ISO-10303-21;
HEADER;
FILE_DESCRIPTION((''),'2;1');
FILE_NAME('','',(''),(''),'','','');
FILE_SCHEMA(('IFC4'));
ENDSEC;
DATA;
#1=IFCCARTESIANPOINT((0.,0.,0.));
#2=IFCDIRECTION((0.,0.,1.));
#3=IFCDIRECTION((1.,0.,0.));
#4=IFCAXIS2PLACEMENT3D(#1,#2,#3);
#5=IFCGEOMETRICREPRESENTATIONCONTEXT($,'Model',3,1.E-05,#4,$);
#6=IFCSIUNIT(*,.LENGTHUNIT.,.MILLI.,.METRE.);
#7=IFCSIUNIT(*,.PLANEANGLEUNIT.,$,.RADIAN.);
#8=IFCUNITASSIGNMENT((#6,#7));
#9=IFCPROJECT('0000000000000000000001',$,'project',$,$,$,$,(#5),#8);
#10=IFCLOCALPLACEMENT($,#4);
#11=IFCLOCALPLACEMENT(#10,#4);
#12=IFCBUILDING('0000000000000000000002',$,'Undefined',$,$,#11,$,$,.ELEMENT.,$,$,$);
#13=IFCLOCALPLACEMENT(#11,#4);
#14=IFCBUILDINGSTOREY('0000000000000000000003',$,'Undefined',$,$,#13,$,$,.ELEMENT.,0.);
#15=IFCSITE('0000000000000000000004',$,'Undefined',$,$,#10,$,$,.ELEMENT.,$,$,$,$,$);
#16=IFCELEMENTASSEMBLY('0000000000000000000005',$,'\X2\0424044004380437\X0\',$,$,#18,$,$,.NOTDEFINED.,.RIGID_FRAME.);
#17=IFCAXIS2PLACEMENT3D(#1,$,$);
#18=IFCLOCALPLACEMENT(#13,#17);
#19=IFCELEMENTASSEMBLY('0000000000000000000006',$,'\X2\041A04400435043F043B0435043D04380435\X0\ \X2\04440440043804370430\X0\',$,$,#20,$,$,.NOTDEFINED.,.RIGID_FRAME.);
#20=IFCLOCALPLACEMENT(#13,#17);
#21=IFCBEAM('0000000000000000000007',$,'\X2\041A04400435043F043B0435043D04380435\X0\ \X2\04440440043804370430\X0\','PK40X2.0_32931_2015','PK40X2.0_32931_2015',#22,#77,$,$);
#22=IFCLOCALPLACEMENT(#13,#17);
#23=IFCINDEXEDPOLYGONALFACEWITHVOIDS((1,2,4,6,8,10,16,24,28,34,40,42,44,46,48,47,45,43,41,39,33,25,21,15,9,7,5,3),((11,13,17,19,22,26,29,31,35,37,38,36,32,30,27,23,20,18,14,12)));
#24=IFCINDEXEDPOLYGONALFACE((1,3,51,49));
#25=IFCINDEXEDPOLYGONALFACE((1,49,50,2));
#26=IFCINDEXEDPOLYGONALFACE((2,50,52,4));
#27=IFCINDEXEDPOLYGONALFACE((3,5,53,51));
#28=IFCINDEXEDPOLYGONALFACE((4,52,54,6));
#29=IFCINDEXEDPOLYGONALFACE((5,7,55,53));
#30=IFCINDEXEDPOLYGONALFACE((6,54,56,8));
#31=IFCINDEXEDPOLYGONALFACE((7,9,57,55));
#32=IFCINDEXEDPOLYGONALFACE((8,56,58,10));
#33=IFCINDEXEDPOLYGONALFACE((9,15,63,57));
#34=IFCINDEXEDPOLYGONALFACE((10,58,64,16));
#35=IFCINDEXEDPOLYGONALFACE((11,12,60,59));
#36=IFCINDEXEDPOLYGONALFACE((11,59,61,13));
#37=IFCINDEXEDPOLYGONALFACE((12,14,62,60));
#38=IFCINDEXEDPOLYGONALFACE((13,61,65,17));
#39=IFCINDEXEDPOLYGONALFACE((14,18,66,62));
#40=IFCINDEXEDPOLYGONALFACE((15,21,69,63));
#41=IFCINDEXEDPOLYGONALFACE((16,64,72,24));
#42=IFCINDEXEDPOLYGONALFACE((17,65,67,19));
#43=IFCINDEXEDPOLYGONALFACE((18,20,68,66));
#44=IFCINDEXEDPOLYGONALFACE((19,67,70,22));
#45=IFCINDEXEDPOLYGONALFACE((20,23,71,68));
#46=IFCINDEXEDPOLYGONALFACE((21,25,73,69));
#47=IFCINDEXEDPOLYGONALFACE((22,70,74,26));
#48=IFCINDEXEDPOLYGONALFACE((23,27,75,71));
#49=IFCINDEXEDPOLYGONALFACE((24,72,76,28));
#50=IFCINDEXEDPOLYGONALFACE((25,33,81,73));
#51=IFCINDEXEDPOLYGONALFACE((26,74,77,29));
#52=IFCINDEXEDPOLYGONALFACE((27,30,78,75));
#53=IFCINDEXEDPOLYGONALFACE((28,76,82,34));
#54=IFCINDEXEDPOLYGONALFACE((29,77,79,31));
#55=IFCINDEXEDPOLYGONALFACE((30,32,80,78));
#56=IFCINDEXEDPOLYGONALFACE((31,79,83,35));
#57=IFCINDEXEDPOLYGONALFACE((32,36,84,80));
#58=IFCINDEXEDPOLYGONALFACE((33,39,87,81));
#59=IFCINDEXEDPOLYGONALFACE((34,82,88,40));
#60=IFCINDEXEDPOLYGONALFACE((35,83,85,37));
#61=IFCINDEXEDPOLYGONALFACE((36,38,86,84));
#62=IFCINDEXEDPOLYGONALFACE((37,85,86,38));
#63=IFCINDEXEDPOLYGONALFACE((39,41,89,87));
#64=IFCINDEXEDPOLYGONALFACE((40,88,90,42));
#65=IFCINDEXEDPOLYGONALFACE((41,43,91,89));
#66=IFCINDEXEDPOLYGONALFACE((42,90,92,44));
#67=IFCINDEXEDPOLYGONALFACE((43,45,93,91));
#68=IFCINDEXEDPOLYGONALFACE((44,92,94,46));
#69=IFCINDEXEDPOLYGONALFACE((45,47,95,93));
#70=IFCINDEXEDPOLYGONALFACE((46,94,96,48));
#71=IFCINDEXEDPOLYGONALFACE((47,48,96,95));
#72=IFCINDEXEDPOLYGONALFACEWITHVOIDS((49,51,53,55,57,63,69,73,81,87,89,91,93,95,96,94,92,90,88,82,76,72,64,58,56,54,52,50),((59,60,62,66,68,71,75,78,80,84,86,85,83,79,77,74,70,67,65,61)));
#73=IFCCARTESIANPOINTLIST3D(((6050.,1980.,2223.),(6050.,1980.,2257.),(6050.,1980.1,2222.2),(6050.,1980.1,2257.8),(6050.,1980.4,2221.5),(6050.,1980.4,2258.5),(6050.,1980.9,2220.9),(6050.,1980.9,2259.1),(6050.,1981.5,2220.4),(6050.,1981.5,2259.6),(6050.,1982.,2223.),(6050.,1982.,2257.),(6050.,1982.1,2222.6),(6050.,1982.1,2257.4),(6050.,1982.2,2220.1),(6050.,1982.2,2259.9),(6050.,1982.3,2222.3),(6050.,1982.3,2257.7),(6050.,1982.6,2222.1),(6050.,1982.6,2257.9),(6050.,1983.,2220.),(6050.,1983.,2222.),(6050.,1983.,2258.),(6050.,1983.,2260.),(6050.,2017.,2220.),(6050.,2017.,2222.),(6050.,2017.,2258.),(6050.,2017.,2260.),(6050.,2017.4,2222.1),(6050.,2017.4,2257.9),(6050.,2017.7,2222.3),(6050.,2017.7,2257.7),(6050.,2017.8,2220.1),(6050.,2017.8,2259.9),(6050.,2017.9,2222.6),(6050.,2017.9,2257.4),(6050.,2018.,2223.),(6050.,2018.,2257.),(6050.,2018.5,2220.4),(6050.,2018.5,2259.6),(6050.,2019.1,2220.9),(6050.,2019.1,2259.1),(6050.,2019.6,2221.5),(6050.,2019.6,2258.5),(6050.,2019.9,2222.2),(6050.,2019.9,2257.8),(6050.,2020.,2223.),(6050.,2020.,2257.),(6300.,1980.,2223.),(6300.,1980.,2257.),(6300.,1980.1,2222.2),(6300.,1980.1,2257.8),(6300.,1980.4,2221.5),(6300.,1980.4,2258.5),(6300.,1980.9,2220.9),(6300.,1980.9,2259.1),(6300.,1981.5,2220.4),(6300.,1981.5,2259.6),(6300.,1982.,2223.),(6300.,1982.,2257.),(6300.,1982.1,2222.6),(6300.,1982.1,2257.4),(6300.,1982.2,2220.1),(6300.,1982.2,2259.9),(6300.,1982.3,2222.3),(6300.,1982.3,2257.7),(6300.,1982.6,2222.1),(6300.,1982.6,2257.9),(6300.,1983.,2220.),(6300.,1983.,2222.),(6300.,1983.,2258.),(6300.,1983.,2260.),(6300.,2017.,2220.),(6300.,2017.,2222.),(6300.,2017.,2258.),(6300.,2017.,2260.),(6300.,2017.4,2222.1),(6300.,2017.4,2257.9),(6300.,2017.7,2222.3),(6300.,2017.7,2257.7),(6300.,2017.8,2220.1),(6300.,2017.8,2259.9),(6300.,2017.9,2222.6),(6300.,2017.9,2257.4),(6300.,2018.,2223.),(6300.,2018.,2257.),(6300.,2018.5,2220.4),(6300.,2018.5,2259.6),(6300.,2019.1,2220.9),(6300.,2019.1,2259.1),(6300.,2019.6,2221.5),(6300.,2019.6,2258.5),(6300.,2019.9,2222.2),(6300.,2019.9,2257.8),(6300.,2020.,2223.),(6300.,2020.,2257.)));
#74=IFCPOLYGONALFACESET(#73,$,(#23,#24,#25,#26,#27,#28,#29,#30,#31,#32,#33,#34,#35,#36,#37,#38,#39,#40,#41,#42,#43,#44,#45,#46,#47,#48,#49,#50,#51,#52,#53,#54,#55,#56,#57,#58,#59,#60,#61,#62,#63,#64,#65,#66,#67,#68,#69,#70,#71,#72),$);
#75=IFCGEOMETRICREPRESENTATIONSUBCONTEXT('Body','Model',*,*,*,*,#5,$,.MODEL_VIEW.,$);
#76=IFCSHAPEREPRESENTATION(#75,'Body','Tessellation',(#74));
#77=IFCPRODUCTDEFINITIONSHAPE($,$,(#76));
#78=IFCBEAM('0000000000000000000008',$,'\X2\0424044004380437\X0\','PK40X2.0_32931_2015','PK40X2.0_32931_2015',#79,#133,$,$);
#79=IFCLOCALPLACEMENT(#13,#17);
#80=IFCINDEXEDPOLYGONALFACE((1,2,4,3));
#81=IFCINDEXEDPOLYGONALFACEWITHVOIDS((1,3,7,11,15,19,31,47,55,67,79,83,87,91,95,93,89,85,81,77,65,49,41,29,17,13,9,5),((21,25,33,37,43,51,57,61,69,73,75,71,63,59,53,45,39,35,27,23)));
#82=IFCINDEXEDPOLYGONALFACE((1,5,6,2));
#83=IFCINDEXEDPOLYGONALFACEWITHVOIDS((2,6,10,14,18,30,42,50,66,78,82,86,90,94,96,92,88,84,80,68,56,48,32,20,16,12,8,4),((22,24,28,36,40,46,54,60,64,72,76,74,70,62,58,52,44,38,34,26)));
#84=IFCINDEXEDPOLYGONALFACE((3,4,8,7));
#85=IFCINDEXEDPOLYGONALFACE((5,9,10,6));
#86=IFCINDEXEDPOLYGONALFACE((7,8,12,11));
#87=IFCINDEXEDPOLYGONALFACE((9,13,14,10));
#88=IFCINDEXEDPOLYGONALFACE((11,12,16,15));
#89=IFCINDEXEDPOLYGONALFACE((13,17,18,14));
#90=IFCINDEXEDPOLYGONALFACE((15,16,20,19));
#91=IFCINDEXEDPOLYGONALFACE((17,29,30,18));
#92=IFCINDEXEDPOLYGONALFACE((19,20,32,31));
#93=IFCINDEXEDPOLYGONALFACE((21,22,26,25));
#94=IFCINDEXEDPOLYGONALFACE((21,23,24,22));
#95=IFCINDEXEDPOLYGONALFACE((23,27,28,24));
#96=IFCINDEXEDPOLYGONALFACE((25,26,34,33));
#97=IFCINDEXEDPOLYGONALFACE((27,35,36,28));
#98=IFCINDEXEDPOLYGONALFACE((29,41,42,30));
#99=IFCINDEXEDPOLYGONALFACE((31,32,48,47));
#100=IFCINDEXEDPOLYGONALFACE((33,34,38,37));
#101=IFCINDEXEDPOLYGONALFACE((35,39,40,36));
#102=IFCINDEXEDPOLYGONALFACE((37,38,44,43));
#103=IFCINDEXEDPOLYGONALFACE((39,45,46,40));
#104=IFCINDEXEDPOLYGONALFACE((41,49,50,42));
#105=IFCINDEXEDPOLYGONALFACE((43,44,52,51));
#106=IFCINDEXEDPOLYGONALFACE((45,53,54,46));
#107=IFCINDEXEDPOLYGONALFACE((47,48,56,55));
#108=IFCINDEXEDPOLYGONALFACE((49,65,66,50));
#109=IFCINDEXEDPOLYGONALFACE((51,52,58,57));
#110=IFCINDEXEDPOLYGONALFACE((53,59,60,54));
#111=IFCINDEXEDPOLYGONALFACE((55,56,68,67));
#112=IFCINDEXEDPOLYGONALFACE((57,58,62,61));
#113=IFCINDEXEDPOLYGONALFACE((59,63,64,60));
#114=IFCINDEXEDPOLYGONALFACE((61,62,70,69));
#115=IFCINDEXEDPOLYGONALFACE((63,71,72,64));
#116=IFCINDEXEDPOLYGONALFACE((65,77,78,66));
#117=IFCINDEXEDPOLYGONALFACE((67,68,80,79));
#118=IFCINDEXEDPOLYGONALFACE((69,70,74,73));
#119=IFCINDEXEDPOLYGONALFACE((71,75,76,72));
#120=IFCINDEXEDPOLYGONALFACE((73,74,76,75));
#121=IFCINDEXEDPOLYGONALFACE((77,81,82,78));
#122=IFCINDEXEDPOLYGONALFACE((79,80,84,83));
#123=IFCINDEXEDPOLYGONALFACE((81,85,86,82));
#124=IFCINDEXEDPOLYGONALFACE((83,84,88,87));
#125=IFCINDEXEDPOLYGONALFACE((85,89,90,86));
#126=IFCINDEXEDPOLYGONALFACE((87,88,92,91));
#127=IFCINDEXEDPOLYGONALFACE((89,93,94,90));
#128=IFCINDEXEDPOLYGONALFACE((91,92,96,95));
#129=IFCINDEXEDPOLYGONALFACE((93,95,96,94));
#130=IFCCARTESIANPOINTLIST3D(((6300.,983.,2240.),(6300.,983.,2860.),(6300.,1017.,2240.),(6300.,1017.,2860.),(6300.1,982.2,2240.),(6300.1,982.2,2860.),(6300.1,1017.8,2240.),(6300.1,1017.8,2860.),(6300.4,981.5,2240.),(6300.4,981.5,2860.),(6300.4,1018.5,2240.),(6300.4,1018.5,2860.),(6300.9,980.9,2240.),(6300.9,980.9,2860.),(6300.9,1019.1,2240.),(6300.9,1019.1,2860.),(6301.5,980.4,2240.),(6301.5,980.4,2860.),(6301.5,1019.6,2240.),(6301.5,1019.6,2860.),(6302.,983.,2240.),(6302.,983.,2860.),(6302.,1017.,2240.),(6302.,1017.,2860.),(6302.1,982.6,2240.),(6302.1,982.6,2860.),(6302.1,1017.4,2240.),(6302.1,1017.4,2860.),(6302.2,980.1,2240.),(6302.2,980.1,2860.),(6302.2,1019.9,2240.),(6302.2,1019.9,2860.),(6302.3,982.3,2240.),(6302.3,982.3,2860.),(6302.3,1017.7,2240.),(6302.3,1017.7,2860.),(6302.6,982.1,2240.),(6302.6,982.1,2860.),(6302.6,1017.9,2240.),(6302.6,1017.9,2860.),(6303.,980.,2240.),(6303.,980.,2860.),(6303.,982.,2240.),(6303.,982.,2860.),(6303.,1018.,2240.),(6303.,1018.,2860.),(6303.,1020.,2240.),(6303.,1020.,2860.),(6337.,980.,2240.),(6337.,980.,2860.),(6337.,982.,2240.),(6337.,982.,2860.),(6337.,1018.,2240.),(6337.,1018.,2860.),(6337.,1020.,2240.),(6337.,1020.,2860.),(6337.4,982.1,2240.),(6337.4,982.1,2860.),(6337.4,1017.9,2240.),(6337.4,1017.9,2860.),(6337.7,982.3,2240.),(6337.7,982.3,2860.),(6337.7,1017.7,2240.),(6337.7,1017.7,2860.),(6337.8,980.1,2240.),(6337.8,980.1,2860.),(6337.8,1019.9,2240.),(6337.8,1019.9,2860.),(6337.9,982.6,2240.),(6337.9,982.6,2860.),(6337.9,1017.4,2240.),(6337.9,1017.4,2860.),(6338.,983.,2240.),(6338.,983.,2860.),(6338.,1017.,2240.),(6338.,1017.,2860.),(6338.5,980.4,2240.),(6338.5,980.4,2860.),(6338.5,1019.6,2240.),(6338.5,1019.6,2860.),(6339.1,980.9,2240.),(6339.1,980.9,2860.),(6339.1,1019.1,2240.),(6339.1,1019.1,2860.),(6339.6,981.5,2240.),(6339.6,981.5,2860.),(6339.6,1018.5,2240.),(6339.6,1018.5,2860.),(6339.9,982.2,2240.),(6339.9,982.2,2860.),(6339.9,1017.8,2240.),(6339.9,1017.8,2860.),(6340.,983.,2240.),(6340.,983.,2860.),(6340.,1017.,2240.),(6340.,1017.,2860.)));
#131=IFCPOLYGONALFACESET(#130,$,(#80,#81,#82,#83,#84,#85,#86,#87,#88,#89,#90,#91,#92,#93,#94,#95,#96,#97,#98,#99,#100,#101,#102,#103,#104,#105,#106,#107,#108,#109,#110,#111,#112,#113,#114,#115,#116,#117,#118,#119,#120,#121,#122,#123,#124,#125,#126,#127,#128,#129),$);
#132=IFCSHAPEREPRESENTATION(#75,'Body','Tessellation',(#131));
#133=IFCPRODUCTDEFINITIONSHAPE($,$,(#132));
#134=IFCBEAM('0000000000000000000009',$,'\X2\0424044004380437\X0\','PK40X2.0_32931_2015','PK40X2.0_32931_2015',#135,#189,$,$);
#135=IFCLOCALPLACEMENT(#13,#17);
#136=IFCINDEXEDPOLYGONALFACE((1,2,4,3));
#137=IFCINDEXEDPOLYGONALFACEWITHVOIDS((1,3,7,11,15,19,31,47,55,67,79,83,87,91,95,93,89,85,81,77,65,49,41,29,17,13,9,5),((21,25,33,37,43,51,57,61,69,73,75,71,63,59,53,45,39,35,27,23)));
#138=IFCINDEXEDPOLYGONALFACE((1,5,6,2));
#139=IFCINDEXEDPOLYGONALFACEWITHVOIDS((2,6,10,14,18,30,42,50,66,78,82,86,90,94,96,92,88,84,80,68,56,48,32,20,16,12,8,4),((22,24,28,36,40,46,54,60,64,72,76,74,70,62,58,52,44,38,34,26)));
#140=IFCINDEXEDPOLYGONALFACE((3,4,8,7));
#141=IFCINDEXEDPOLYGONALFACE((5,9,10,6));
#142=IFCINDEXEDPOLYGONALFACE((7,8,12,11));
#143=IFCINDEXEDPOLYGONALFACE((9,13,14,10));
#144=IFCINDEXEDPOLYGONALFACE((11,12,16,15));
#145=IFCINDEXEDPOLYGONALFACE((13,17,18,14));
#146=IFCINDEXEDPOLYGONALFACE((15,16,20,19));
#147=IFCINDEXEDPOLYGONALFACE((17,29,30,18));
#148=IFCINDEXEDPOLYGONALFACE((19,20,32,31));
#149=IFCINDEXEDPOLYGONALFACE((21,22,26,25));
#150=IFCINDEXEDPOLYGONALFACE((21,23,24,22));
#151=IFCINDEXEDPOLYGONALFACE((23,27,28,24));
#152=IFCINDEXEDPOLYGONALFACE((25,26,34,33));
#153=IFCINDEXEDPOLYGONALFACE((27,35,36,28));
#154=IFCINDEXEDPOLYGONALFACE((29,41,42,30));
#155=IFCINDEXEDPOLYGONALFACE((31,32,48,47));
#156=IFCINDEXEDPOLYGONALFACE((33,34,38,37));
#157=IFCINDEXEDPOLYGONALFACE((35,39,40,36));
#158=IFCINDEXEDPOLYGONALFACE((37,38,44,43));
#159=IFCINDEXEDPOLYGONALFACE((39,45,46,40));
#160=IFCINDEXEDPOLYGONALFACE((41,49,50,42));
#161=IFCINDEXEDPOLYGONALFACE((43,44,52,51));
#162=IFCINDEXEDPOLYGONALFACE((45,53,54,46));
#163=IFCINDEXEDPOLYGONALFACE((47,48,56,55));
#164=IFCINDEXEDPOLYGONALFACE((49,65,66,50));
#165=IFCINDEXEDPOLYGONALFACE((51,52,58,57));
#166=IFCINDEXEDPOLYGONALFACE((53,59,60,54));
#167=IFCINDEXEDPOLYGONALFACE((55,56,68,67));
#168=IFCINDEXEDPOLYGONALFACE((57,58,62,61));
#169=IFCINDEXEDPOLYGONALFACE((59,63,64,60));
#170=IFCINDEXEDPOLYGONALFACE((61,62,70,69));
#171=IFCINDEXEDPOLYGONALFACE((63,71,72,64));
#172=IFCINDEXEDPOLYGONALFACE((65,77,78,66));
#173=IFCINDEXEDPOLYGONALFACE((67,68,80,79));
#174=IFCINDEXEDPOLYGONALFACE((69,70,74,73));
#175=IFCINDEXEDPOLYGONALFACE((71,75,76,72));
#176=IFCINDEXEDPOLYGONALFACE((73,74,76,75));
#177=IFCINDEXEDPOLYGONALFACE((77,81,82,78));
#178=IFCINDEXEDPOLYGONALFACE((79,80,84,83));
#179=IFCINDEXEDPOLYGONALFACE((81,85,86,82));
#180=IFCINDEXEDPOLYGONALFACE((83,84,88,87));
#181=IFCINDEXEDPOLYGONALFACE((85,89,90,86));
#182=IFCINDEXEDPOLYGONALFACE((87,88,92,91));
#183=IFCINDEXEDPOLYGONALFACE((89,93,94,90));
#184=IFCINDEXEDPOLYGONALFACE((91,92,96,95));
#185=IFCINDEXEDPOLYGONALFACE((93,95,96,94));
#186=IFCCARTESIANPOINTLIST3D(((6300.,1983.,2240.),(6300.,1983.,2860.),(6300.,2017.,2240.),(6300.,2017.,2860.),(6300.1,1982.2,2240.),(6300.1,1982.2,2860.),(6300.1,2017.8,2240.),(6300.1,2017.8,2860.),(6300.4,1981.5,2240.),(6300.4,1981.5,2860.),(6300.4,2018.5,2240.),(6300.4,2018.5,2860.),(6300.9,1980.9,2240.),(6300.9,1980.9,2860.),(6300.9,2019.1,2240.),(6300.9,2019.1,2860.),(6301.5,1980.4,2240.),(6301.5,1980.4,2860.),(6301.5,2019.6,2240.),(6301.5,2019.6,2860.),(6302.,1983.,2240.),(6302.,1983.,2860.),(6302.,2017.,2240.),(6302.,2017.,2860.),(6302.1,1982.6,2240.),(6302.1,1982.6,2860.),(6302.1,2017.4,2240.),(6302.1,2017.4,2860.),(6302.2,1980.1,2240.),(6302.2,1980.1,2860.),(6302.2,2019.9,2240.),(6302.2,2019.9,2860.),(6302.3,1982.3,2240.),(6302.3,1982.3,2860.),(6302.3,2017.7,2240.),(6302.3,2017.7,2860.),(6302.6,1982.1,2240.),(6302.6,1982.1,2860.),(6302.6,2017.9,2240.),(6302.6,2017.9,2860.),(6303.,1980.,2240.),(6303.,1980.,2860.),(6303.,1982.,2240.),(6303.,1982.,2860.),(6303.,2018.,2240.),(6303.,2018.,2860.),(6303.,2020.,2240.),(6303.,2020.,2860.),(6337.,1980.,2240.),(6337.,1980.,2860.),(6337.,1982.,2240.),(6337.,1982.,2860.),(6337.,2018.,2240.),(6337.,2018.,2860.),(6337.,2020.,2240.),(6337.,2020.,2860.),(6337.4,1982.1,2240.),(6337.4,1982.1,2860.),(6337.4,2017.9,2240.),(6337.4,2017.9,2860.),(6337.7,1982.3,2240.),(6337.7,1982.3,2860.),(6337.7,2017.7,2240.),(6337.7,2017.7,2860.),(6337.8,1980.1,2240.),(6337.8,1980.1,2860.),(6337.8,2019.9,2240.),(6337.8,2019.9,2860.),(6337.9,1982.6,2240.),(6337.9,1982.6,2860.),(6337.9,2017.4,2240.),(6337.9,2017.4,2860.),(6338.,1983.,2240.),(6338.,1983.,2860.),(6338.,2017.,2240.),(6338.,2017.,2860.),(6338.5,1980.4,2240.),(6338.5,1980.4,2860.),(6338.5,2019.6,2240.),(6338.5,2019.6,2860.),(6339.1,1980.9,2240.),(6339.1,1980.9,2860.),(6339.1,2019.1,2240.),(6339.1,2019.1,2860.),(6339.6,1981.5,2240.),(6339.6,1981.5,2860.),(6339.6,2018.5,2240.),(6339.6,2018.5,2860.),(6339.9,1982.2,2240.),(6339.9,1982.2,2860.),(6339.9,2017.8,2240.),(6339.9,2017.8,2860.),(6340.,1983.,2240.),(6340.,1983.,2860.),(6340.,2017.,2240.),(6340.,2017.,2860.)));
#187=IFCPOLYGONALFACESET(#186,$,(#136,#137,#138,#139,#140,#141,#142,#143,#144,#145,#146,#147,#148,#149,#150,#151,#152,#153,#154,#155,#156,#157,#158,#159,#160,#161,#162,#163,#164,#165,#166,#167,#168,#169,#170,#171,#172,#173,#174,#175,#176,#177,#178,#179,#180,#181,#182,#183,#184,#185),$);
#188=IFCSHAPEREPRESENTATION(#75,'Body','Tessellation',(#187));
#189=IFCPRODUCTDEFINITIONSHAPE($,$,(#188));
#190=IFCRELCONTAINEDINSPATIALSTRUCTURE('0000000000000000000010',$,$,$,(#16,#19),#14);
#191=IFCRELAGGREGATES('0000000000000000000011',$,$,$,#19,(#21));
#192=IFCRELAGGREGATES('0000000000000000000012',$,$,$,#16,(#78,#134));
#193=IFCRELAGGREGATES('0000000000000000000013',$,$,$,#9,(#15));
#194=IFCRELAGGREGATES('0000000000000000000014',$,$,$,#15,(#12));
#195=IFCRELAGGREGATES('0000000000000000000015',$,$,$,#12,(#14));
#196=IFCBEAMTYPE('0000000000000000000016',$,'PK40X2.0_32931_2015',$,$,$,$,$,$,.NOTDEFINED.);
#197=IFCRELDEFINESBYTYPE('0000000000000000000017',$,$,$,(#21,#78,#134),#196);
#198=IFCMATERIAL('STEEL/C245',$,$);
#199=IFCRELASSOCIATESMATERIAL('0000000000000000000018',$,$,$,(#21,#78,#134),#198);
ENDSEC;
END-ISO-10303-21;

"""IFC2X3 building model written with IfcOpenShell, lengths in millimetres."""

from ifc_helpers import new_model, si_unit, frame, origin_with_axes, origin_2d_with_axis, place, context, subcontext, project, spatial, hollow_rectangle, extrude, material, type_object, element, aggregate, save


model = new_model("IFC2X3")

# Units and contexts
model_context = context("Model", 3, precision=1e-05, world=origin_with_axes())
body_context = subcontext(model_context, "Body", "Model", "MODEL_VIEW")
ifc_project = project(units=[si_unit("LENGTHUNIT", "METRE", prefix="MILLI"), si_unit("PLANEANGLEUNIT", "RADIAN")], contexts=[model_context])

# Site, building, storey
site_placement = place(None, origin_with_axes())
site = spatial("IfcSite", under=ifc_project, at=site_placement, Name="Undefined", CompositionType="ELEMENT")
building_placement = place(site_placement, origin_with_axes())
building = spatial("IfcBuilding", under=site, at=building_placement, Name="Undefined", CompositionType="ELEMENT")
storey_placement = place(building_placement, origin_with_axes())
storey = spatial("IfcBuildingStorey", under=building, at=storey_placement, Name="Undefined", CompositionType="ELEMENT", Elevation=0.0)

# Shared definitions
ifc_material_1 = material(Name="STEEL/C245")

# Element assembly
assembly_1_placement = place(storey_placement, origin_with_axes())
assembly_1 = element("IfcElementAssembly", 1, at=assembly_1_placement, inside=storey, Name="Фриз", AssemblyPlace="NOTDEFINED", PredefinedType="RIGID_FRAME")

# Element assembly, beam
beam_type_1 = type_object("IfcBeamType", Name="PK40X2.0_32931_2015", PredefinedType="NOTDEFINED")
assembly_2_placement = place(storey_placement, origin_with_axes())
assembly_2 = element("IfcElementAssembly", 2, at=assembly_2_placement, inside=storey, Name="Крепление фриза", AssemblyPlace="NOTDEFINED", PredefinedType="RIGID_FRAME")
beam_1_placement = place(assembly_2_placement, frame((6300.0, 2000.0, 2240.0), z_axis=(0.0, 0.0, -1.0), x_axis=(-1.0, 0.0, 0.0)))
beam_1 = element("IfcBeam", 3, at=beam_1_placement, type_object=beam_type_1, material=ifc_material_1, Name="Крепление фриза", Description="PK40X2.0_32931_2015", ObjectType="PK40X2.0_32931_2015", context=body_context, shape_type="SweptSolid", body=[
    extrude(hollow_rectangle(XDim=40.0, YDim=40.0, WallThickness=2.0, InnerFilletRadius=1.0, OuterFilletRadius=3.0, at=origin_2d_with_axis()), frame((250.0, 0.0, 0.0), z_axis=(-1.0, 0.0, 0.0), x_axis=(0.0, -1.0, 0.0)), (0.0, 0.0, 1.0), 250.0),
])
aggregate(assembly_2, [beam_1])

# Beams
beam_2_placement = place(assembly_1_placement, frame((6320.0, 1000.0, 2860.0), z_axis=(-1.0, 0.0, 0.0), x_axis=(0.0, 0.0, -1.0)))
beam_2 = element("IfcBeam", 4, at=beam_2_placement, type_object=beam_type_1, material=ifc_material_1, Name="Фриз", Description="PK40X2.0_32931_2015", ObjectType="PK40X2.0_32931_2015", context=body_context, shape_type="SweptSolid", body=[
    extrude(hollow_rectangle(XDim=40.0, YDim=40.0, WallThickness=2.0, InnerFilletRadius=1.0, OuterFilletRadius=3.0, at=origin_2d_with_axis()), frame((620.0, 0.0, 0.0), z_axis=(-1.0, 0.0, 0.0), x_axis=(0.0, -1.0, 0.0)), (0.0, 0.0, 1.0), 620.0),
])
beam_3_placement = place(assembly_1_placement, frame((6320.0, 2000.0, 2860.0), z_axis=(-1.0, 0.0, 0.0), x_axis=(0.0, 0.0, -1.0)))
beam_3 = element("IfcBeam", 5, at=beam_3_placement, type_object=beam_type_1, material=ifc_material_1, Name="Фриз", Description="PK40X2.0_32931_2015", ObjectType="PK40X2.0_32931_2015", context=body_context, shape_type="SweptSolid", body=[
    extrude(hollow_rectangle(XDim=40.0, YDim=40.0, WallThickness=2.0, InnerFilletRadius=1.0, OuterFilletRadius=3.0, at=origin_2d_with_axis()), frame((620.0, 0.0, 0.0), z_axis=(-1.0, 0.0, 0.0), x_axis=(0.0, -1.0, 0.0)), (0.0, 0.0, 1.0), 620.0),
])
aggregate(assembly_1, [beam_2, beam_3])

save(model, "model.ifc")
